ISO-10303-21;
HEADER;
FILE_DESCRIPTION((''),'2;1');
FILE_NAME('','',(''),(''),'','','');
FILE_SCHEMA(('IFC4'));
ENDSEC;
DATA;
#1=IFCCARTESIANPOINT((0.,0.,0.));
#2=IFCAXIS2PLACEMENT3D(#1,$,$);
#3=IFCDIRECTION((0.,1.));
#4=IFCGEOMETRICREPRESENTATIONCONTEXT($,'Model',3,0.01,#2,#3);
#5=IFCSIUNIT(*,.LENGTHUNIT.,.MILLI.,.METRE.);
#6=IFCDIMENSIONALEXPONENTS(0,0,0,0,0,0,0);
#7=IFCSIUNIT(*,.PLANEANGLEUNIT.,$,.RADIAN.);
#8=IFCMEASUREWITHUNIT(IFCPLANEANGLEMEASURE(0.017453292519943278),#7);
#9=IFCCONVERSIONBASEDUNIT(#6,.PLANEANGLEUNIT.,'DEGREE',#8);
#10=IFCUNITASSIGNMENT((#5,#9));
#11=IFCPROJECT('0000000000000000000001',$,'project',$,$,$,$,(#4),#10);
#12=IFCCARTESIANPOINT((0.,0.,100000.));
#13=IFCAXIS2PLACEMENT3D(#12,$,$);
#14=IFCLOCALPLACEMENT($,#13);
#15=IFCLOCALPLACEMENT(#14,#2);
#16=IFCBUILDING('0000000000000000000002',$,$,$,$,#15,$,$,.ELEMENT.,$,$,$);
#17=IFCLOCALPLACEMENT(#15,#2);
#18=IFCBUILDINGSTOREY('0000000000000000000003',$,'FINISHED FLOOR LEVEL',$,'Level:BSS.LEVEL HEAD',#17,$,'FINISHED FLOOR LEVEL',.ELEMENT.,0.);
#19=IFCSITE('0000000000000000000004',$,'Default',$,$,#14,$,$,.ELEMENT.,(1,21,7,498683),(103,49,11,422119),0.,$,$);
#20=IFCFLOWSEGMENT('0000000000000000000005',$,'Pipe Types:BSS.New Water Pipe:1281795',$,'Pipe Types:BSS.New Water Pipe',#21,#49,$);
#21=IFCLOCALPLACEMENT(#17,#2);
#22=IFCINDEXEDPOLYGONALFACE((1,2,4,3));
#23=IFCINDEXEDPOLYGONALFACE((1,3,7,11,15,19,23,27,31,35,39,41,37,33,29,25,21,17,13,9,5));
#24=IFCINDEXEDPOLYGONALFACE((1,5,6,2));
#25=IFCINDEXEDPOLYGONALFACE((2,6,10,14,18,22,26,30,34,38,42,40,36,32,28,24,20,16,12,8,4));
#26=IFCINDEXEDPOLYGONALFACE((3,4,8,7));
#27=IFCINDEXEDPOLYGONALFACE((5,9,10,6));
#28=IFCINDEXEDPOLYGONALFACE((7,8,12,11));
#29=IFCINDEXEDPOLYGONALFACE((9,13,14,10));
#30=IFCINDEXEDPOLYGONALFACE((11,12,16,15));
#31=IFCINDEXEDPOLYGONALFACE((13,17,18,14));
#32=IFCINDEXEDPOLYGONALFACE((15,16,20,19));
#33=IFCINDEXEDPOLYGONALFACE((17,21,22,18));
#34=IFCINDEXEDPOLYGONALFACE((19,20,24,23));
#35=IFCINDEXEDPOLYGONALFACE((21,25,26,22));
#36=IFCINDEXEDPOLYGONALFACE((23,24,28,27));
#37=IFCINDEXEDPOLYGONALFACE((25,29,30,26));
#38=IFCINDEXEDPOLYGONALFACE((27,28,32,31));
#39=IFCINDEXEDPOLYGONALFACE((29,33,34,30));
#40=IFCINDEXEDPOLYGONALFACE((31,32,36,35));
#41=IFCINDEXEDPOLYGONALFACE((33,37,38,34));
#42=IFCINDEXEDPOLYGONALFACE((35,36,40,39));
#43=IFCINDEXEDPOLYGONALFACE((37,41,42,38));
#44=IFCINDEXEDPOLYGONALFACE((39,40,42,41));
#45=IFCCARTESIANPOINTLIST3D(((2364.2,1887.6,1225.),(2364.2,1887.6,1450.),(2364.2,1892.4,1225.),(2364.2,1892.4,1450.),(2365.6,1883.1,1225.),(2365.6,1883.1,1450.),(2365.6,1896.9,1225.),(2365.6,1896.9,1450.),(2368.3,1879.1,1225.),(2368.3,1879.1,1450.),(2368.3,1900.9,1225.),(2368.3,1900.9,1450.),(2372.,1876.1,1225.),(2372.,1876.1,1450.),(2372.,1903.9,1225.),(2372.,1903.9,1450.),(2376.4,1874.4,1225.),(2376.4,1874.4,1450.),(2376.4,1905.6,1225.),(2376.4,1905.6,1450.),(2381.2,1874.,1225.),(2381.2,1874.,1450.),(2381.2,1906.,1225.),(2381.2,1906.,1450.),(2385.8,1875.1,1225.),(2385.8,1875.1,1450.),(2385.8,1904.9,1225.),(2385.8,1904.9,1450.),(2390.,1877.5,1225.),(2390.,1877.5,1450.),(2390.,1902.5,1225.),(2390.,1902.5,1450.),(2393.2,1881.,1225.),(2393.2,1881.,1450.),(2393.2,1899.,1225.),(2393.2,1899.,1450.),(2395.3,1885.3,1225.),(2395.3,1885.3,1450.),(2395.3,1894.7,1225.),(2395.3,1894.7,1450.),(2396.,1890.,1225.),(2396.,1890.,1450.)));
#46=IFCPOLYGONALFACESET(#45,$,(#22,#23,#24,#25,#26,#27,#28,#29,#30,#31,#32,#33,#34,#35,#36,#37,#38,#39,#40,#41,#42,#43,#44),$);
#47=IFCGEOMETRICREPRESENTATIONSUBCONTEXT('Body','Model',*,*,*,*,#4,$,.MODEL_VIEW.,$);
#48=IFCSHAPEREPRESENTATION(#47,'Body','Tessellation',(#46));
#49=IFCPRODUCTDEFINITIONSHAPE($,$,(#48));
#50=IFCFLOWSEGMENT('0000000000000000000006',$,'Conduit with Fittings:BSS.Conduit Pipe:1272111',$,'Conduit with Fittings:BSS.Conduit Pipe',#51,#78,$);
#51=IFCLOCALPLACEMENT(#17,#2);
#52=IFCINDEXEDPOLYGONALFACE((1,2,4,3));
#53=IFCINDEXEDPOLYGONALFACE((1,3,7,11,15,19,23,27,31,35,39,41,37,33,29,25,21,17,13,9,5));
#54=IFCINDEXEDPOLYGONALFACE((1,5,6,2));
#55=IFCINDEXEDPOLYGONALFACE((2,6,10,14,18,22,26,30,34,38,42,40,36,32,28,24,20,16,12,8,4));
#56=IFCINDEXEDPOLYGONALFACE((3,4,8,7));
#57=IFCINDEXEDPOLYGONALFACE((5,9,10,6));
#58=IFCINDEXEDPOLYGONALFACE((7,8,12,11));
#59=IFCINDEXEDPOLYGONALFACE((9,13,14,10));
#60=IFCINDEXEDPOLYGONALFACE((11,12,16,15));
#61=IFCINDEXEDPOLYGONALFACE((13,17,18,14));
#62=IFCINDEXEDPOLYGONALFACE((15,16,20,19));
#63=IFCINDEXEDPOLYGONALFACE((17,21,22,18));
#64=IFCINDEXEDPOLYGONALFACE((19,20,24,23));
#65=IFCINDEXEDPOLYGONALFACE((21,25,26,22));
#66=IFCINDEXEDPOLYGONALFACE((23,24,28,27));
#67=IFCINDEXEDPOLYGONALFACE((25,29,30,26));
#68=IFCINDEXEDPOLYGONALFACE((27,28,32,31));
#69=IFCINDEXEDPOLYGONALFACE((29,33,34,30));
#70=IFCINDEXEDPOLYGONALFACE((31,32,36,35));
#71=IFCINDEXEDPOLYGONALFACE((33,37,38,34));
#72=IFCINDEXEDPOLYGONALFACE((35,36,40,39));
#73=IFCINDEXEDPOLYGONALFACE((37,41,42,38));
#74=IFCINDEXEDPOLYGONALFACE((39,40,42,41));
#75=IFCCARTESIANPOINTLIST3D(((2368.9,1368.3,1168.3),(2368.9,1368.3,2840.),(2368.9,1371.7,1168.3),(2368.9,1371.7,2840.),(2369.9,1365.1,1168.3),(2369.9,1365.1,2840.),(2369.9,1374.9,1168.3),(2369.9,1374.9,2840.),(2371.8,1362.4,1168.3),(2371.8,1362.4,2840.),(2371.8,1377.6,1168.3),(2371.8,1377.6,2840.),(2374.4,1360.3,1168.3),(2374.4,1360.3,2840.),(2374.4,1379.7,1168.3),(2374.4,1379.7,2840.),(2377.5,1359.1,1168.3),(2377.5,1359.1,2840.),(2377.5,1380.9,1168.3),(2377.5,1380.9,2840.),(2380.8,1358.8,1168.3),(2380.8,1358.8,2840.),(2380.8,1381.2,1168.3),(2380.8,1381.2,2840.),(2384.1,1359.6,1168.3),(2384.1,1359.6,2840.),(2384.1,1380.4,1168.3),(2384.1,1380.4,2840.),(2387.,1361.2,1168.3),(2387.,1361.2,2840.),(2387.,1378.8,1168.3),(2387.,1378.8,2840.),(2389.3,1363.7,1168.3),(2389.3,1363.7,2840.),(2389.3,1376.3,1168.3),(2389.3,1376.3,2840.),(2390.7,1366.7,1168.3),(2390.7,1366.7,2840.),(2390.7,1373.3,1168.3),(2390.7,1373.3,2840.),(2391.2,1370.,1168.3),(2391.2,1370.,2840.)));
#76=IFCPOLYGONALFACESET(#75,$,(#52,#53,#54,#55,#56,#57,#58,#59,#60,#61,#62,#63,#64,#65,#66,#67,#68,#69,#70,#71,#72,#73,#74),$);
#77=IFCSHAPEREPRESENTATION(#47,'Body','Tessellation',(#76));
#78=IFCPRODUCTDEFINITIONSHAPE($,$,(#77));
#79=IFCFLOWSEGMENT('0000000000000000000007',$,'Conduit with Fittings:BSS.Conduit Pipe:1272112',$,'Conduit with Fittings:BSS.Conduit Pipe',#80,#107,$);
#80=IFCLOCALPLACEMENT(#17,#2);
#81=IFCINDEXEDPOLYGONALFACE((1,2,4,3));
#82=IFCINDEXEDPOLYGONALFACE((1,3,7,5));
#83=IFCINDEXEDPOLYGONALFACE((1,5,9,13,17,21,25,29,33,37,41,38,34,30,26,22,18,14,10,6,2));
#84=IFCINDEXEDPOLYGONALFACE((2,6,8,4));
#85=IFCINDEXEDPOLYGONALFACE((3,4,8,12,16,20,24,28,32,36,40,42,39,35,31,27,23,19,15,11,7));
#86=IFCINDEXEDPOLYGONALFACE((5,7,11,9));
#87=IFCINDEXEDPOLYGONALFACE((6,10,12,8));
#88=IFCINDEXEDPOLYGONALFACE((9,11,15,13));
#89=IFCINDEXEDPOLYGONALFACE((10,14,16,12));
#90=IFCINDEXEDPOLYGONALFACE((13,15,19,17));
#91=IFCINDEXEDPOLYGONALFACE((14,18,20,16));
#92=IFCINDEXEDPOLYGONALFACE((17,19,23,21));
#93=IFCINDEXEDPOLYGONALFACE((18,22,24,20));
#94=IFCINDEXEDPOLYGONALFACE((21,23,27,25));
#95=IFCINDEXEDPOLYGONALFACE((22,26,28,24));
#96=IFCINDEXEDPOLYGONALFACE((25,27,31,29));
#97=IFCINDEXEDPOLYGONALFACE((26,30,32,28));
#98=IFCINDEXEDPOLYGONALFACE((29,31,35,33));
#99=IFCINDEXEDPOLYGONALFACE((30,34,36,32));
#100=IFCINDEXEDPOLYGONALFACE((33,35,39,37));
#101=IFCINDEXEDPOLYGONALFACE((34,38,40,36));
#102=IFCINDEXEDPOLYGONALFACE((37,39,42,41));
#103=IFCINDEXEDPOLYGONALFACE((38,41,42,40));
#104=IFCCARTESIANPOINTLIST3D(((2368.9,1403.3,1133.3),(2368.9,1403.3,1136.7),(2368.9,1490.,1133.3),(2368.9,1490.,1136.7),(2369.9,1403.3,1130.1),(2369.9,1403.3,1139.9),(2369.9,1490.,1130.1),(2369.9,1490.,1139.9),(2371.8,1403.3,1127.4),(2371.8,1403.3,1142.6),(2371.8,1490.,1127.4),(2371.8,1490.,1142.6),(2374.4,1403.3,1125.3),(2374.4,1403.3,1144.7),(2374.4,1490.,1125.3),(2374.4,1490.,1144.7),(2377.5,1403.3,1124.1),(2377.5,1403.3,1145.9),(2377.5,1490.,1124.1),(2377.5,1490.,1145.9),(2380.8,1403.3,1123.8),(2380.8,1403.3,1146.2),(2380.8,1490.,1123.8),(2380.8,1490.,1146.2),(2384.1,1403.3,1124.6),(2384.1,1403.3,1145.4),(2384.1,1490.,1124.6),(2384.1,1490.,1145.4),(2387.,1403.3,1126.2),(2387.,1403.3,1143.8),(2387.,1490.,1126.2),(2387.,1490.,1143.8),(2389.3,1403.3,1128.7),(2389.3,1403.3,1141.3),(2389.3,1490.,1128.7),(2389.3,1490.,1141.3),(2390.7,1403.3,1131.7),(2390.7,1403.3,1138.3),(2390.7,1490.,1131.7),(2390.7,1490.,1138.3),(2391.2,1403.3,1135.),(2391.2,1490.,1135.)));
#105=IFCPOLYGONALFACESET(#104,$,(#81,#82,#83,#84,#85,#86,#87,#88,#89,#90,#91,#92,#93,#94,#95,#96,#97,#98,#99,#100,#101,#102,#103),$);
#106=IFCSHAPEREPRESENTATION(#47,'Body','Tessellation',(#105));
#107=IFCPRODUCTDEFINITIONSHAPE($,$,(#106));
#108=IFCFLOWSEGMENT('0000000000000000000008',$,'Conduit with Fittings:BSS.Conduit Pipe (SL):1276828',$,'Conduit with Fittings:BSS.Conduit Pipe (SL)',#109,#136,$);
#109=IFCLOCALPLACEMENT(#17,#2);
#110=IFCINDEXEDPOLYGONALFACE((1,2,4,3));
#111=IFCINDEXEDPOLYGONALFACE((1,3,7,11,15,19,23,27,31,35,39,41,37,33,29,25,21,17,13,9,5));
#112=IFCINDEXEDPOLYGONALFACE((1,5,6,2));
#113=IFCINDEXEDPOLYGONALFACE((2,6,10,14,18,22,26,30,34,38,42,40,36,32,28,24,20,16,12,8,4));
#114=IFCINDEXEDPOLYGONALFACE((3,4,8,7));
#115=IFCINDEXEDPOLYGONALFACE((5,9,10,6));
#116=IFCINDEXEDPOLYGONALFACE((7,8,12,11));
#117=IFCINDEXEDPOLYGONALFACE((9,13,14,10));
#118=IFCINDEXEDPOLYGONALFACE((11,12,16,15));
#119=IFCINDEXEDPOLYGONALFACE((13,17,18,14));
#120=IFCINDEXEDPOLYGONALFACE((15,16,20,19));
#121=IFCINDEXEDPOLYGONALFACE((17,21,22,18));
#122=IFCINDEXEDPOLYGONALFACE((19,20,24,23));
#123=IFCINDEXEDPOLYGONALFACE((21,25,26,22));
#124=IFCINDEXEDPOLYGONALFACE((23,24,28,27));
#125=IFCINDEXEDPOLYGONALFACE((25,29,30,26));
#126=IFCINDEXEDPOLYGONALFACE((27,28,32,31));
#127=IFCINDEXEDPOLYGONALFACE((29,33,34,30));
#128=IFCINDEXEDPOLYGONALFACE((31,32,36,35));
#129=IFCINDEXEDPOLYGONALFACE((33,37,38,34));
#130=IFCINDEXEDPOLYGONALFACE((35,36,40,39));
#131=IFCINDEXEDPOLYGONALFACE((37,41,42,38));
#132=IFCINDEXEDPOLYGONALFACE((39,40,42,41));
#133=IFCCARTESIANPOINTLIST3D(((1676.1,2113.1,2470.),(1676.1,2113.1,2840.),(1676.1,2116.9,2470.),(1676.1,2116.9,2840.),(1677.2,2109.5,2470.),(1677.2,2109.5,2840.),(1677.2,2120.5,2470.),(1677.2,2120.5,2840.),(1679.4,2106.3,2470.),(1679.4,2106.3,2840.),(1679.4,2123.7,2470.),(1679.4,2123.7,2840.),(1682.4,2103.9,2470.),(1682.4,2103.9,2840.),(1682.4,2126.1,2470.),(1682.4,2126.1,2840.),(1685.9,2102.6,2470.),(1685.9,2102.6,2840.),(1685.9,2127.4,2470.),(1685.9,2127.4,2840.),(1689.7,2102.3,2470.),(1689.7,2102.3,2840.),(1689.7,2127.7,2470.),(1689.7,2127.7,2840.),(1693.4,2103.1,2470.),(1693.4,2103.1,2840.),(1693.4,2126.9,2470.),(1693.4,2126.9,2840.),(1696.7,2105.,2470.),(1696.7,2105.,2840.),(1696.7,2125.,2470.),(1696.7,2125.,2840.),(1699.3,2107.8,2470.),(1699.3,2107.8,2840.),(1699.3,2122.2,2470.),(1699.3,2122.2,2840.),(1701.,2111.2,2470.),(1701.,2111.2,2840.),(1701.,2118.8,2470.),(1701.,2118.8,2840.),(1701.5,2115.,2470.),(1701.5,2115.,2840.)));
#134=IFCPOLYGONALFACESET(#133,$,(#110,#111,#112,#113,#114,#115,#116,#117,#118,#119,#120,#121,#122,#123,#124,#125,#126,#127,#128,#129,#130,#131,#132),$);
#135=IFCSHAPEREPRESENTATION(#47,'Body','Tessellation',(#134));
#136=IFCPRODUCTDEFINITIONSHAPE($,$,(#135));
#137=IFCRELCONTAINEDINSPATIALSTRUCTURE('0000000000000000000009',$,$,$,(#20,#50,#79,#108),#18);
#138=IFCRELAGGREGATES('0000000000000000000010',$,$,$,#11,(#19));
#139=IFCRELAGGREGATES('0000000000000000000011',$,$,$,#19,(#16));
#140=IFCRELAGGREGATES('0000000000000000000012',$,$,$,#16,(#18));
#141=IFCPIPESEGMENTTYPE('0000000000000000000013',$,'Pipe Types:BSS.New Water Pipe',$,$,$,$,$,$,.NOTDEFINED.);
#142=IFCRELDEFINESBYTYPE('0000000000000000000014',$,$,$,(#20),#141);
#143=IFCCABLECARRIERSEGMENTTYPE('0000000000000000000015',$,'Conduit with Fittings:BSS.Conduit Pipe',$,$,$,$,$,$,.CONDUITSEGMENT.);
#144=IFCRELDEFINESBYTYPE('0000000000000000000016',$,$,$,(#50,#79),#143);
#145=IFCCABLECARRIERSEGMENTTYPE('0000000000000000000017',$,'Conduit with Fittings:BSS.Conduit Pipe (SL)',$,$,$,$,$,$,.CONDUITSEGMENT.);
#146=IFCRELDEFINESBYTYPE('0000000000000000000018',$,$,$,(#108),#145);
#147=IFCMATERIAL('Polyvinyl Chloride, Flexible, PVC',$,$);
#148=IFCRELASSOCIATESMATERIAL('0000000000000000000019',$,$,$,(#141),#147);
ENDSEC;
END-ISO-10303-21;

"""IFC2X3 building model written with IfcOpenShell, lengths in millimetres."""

from ifc_helpers import new_model, entity, si_unit, converted_unit, direction, frame, frame_2d, origin, place, context, subcontext, project, spatial, circle, extrude, material, type_object, element, save


model = new_model("IFC2X3")

# Units and contexts
model_context = context("Model", 3, precision=0.01, world=origin(), true_north=direction((0.0, 1.0)))
body_context = subcontext(model_context, "Body", "Model", "MODEL_VIEW")
ifc_project = project(units=[si_unit("LENGTHUNIT", "METRE", prefix="MILLI"), converted_unit("PLANEANGLEUNIT", "DEGREE", entity("IfcPlaneAngleMeasure", 0.017453292519943278), si_unit("PLANEANGLEUNIT", "RADIAN"), dimensions=[0, 0, 0, 0, 0, 0, 0])], contexts=[model_context])

# Site, building, storey
site_placement = place(None, frame((0.0, 0.0, 100000.0)))
site = spatial("IfcSite", under=ifc_project, at=site_placement, Name="Default", CompositionType="ELEMENT", RefLatitude=(1, 21, 7, 498683), RefLongitude=(103, 49, 11, 422119), RefElevation=0.0)
building_placement = place(site_placement, origin())
building = spatial("IfcBuilding", under=site, at=building_placement, CompositionType="ELEMENT")
storey_placement = place(building_placement, origin())
storey = spatial("IfcBuildingStorey", under=building, at=storey_placement, Name="FINISHED FLOOR LEVEL", ObjectType="Level:BSS.LEVEL HEAD", LongName="FINISHED FLOOR LEVEL", CompositionType="ELEMENT", Elevation=0.0)

# Flow segments
ifc_material_1 = material(Name="Polyvinyl Chloride, Flexible, PVC")
pipe_segment_type_1 = type_object("IfcPipeSegmentType", Name="Pipe Types:BSS.New Water Pipe", PredefinedType="NOTDEFINED", material=ifc_material_1)
flow_segment_1_placement = place(storey_placement, origin())
element("IfcFlowSegment", 1, at=flow_segment_1_placement, inside=storey, type_object=pipe_segment_type_1, Name="Pipe Types:BSS.New Water Pipe:1281795", ObjectType="Pipe Types:BSS.New Water Pipe", context=body_context, shape_type="SweptSolid", body=[
    extrude(circle(Radius=16.0, at=frame_2d((0.0, 0.0), x_axis=(1.0, 0.0))), frame((2380.0, 1890.0, 1225.0)), (0.0, 0.0, 1.0), 225.0),
])
cable_carrier_segment_type_1 = type_object("IfcCableCarrierSegmentType", Name="Conduit with Fittings:BSS.Conduit Pipe", PredefinedType="CONDUITSEGMENT")
flow_segment_2_placement = place(storey_placement, origin())
element("IfcFlowSegment", 2, at=flow_segment_2_placement, inside=storey, type_object=cable_carrier_segment_type_1, Name="Conduit with Fittings:BSS.Conduit Pipe:1272111", ObjectType="Conduit with Fittings:BSS.Conduit Pipe", context=body_context, shape_type="SweptSolid", body=[
    extrude(circle(Radius=11.2, at=frame_2d((0.0, 0.0), x_axis=(1.0, 0.0))), frame((2380.0, 1370.0, 1168.3)), (0.0, 0.0, 1.0), 1671.7),
])
flow_segment_3_placement = place(storey_placement, origin())
element("IfcFlowSegment", 3, at=flow_segment_3_placement, inside=storey, type_object=cable_carrier_segment_type_1, Name="Conduit with Fittings:BSS.Conduit Pipe:1272112", ObjectType="Conduit with Fittings:BSS.Conduit Pipe", context=body_context, shape_type="SweptSolid", body=[
    extrude(circle(Radius=11.2, at=frame_2d((0.0, 0.0), x_axis=(1.0, 0.0))), frame((2380.0, 1403.3, 1135.0), z_axis=(0.0, 1.0, 0.0), x_axis=(1.0, 0.0, 0.0)), (0.0, 0.0, 1.0), 86.7),
])
cable_carrier_segment_type_2 = type_object("IfcCableCarrierSegmentType", Name="Conduit with Fittings:BSS.Conduit Pipe (SL)", PredefinedType="CONDUITSEGMENT")
flow_segment_4_placement = place(storey_placement, origin())
element("IfcFlowSegment", 4, at=flow_segment_4_placement, inside=storey, type_object=cable_carrier_segment_type_2, Name="Conduit with Fittings:BSS.Conduit Pipe (SL):1276828", ObjectType="Conduit with Fittings:BSS.Conduit Pipe (SL)", context=body_context, shape_type="SweptSolid", body=[
    extrude(circle(Radius=12.8, at=frame_2d((0.0, 0.0), x_axis=(1.0, 0.0))), frame((1688.7, 2115.0, 2470.0)), (0.0, 0.0, 1.0), 370.0),
])

save(model, "model.ifc")
